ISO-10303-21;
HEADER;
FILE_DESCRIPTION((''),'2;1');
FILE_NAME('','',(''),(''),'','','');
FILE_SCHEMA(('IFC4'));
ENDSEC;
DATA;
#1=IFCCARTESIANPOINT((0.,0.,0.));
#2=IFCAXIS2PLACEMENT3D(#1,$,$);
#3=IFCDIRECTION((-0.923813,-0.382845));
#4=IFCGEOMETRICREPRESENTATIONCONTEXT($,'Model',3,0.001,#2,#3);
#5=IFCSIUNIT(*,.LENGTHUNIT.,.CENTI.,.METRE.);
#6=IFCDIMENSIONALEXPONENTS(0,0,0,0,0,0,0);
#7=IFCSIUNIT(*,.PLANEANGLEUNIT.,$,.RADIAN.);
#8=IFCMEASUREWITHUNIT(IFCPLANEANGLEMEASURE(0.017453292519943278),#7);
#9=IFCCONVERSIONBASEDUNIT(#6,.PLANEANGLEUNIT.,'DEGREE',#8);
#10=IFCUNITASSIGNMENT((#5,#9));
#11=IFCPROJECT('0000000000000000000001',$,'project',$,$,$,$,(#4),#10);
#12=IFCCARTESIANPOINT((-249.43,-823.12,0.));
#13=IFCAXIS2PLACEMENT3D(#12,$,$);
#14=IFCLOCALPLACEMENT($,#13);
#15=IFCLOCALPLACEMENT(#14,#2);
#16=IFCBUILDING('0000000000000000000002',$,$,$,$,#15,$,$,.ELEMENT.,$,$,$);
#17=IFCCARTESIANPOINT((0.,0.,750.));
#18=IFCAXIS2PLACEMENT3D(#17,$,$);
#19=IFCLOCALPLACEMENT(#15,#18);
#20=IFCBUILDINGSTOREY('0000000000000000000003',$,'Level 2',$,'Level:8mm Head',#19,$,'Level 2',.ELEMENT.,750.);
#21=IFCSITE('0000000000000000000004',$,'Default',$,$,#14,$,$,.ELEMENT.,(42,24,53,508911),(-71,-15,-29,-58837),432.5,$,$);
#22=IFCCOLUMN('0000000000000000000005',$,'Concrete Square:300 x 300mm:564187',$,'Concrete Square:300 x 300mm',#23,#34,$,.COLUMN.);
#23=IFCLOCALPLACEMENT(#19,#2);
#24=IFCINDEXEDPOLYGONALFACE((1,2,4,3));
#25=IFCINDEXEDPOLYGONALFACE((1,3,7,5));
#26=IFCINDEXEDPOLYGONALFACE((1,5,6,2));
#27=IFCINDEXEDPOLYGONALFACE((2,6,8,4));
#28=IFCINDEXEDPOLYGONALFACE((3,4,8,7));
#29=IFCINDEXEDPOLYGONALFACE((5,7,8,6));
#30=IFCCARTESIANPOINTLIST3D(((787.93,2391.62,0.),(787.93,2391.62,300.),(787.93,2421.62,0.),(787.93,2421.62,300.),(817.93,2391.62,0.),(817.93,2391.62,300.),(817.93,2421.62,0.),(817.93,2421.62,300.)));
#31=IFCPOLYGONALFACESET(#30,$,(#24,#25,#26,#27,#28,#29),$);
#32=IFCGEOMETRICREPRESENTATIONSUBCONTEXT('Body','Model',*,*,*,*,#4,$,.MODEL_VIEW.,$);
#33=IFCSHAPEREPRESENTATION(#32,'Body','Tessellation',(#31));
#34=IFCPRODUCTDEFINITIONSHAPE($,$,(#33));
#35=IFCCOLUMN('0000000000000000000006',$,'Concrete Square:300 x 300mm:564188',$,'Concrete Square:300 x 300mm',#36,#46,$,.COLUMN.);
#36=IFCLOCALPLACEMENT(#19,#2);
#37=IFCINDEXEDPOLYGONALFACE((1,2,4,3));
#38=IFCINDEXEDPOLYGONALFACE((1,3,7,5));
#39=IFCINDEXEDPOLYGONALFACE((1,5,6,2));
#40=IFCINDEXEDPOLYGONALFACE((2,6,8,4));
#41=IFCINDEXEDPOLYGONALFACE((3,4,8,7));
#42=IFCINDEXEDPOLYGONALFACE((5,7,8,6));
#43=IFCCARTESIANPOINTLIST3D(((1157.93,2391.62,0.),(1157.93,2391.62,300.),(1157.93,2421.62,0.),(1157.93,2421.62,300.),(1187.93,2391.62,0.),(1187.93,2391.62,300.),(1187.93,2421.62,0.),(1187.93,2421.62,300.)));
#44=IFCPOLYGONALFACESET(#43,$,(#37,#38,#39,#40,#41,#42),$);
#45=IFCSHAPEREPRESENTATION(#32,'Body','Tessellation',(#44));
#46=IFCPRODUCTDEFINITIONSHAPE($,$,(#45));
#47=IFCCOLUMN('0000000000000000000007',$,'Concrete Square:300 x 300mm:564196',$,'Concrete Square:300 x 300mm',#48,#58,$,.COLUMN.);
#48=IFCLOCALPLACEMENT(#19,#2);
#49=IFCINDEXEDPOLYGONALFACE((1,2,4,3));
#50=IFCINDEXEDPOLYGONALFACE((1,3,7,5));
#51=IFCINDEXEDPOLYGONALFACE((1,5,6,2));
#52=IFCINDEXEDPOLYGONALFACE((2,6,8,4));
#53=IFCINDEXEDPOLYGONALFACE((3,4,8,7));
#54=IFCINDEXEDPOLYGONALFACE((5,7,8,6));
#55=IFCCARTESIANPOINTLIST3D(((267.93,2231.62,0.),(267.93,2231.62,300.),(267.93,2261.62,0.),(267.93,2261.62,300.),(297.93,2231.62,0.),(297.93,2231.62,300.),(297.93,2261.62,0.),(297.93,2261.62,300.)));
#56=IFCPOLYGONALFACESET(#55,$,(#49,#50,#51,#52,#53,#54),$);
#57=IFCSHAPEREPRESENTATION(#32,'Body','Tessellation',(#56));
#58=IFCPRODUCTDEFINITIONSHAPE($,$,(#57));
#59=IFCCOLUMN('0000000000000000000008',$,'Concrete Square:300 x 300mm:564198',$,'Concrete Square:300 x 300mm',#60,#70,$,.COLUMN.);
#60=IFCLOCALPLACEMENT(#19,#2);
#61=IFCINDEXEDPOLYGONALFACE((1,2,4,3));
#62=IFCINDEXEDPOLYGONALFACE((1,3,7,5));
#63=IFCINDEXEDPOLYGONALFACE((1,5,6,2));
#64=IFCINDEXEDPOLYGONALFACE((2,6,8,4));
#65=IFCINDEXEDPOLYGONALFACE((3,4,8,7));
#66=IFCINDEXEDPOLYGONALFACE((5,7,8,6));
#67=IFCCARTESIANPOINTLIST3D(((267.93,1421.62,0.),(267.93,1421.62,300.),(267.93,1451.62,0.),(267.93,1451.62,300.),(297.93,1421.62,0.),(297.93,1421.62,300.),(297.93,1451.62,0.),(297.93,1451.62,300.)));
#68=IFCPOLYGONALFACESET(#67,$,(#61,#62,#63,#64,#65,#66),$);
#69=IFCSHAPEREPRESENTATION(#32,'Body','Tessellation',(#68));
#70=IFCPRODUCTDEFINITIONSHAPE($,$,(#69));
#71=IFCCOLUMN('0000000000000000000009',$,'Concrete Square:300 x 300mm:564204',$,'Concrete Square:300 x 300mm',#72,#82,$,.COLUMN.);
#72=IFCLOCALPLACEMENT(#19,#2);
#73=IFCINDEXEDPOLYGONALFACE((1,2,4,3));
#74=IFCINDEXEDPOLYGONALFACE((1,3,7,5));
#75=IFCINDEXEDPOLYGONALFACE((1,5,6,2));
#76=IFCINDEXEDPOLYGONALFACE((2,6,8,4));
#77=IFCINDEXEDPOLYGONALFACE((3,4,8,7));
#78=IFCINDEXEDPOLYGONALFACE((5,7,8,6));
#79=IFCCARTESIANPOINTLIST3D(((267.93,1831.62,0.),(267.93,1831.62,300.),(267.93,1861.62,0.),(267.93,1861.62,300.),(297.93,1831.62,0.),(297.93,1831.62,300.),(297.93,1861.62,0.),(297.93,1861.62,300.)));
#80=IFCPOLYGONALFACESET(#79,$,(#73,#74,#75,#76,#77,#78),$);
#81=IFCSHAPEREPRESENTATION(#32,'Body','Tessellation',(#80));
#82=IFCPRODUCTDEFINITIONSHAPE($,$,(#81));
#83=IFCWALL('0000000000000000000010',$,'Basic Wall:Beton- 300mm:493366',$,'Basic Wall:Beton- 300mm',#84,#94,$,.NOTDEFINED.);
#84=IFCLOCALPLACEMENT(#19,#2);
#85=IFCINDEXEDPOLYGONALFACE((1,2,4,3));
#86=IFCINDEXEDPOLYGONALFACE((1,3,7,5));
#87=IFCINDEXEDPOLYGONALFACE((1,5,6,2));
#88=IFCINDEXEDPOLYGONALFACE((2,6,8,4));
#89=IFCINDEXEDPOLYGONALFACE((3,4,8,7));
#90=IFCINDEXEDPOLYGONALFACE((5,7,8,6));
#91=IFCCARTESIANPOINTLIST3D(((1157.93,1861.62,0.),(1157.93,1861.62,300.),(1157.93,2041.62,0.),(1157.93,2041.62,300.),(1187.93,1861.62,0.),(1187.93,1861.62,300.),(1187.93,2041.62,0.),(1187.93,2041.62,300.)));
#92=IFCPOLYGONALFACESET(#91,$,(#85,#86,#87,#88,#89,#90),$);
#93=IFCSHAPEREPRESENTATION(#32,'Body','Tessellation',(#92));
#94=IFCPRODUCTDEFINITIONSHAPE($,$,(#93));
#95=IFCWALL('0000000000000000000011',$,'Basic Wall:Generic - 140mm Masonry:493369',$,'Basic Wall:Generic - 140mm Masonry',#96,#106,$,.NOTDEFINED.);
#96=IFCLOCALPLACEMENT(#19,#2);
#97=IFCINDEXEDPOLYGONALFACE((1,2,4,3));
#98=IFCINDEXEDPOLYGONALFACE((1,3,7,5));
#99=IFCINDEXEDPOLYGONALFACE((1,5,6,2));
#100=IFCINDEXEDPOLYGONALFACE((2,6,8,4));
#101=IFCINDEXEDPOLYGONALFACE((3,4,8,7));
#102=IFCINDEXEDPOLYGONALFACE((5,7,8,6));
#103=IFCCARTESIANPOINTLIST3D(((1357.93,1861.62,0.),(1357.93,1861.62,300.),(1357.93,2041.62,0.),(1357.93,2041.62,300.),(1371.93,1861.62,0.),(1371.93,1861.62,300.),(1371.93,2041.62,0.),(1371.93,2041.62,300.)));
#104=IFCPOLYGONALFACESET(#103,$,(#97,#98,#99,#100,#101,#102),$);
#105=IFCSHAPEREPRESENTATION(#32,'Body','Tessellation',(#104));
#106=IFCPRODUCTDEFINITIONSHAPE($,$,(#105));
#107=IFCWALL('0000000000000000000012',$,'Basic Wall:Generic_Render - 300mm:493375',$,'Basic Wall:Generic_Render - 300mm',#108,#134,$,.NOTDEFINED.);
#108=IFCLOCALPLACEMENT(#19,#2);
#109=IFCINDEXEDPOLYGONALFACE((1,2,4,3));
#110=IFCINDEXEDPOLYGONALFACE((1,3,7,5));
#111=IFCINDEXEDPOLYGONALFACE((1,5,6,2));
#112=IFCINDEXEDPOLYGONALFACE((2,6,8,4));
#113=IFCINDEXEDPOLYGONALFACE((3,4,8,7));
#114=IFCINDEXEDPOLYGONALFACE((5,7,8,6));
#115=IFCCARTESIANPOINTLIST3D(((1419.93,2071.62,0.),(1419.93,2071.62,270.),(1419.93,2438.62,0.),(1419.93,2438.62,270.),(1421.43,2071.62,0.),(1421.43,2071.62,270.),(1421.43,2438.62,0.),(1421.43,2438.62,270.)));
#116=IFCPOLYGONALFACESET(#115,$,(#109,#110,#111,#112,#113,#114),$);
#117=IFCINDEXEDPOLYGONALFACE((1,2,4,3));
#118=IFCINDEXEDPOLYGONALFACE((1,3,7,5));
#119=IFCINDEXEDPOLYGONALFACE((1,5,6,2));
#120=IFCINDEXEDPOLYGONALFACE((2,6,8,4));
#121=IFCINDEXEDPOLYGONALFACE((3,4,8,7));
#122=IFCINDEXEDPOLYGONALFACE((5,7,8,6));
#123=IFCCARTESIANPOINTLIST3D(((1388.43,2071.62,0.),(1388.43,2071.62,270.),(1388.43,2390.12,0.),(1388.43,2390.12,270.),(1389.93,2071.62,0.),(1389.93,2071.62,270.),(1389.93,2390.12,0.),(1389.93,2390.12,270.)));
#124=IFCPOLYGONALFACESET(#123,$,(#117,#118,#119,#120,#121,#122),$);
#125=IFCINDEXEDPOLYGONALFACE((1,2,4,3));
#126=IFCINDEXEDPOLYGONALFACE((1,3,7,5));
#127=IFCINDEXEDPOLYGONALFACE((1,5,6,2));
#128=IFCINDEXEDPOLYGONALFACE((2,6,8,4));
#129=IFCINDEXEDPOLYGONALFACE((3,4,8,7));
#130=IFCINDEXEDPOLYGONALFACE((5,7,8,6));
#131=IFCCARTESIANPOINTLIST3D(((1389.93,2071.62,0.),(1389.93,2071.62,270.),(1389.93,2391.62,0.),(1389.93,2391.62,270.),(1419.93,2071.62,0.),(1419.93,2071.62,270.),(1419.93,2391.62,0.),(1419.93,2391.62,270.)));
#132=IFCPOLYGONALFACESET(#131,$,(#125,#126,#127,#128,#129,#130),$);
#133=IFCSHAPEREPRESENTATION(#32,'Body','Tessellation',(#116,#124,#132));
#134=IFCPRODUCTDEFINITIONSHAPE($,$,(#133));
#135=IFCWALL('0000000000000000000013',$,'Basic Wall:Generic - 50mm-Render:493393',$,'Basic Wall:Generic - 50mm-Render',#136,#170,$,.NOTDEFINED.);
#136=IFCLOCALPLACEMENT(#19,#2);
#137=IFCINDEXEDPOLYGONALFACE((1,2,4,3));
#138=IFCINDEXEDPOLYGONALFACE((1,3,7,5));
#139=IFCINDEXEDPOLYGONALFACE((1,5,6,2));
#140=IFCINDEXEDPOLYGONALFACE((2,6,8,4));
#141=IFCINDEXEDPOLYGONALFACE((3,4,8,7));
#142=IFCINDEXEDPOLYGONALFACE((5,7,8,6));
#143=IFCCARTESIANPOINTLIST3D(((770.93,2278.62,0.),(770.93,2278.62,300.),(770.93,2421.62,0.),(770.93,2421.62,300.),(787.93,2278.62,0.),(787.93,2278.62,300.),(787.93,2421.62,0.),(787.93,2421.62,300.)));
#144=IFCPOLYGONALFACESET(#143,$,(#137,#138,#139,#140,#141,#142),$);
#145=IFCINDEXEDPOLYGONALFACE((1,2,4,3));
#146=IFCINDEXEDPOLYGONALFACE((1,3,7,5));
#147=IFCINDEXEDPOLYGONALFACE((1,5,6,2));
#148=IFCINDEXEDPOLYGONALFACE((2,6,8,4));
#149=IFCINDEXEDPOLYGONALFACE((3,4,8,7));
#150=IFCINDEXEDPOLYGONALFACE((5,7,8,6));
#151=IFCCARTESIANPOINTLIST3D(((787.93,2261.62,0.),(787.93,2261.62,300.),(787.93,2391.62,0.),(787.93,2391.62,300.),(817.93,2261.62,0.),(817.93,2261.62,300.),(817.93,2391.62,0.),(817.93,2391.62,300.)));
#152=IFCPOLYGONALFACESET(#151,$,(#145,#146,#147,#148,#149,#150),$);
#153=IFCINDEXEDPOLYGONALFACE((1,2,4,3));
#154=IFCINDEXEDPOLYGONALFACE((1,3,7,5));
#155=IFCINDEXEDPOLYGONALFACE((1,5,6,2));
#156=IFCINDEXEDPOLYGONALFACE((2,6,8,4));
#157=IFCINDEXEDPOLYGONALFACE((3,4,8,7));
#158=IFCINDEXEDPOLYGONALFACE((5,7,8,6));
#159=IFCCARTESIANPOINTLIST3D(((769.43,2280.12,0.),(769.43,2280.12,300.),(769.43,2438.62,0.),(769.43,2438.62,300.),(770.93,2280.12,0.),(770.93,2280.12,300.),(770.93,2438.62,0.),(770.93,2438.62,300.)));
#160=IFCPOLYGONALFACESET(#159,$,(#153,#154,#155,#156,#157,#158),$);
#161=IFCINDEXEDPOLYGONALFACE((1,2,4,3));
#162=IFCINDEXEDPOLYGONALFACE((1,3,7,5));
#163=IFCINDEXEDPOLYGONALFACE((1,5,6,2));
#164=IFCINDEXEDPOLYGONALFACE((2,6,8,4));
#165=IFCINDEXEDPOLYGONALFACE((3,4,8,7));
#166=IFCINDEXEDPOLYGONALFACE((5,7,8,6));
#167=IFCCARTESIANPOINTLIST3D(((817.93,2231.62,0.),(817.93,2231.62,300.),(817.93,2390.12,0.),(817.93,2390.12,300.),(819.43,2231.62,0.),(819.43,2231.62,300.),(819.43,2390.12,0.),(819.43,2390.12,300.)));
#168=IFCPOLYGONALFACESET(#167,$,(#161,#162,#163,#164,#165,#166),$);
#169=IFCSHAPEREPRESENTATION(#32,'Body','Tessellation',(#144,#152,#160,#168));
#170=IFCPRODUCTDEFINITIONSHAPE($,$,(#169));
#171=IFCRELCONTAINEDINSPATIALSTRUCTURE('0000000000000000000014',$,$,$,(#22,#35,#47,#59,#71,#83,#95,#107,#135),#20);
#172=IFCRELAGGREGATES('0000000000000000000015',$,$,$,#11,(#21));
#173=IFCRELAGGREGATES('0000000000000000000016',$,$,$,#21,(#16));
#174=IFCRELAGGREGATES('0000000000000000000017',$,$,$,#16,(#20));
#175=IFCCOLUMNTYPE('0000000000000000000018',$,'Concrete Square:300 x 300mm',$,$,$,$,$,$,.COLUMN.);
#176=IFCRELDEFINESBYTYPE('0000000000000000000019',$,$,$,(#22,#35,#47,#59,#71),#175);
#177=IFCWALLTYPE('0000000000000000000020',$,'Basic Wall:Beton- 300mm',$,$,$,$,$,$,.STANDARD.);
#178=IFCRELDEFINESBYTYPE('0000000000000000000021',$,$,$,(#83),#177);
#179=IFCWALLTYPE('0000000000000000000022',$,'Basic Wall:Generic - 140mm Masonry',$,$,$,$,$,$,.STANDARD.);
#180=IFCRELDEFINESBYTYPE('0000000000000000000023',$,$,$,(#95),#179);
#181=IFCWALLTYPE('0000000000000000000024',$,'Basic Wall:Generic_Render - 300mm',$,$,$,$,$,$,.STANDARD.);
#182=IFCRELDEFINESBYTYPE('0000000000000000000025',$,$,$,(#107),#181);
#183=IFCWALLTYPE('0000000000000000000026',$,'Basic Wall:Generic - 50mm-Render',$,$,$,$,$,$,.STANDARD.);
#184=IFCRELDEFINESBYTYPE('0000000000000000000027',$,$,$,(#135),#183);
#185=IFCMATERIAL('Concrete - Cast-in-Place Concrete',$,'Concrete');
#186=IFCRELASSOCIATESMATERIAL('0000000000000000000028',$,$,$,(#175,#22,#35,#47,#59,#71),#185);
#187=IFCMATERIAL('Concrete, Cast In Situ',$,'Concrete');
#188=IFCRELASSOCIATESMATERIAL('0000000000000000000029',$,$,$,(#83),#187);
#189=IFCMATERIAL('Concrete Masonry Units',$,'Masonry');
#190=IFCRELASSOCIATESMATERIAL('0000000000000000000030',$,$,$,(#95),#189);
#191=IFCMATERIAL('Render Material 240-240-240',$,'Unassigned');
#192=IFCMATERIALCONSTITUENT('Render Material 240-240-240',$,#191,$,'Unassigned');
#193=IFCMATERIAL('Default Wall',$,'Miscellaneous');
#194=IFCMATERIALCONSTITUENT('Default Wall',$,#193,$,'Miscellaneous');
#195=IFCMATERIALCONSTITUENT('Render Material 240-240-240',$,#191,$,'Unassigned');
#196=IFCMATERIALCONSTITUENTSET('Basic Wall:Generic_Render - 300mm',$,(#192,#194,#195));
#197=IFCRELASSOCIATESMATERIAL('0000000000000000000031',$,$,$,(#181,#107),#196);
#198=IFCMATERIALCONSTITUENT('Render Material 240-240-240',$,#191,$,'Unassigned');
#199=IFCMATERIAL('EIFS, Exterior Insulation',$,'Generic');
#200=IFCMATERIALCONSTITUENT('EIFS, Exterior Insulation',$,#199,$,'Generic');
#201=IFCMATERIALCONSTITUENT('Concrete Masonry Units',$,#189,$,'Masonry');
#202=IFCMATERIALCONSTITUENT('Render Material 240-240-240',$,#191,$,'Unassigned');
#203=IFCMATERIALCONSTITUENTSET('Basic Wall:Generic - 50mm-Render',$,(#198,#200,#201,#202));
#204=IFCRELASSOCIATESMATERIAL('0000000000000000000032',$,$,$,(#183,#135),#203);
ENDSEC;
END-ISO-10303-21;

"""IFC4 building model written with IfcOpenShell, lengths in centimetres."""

from ifc_helpers import new_model, entity, si_unit, converted_unit, direction, frame, origin, place, context, subcontext, project, spatial, indexed_curve, outline, extrude, source, transform, mapped, material, constituent, constituent_set, type_object, type_shapes, element, save


model = new_model("IFC4")

# Units and contexts
model_context = context("Model", 3, precision=0.001, world=origin(), true_north=direction((-0.923813, -0.382845)))
body_context = subcontext(model_context, "Body", "Model", "MODEL_VIEW")
ifc_project = project(units=[si_unit("LENGTHUNIT", "METRE", prefix="CENTI"), converted_unit("PLANEANGLEUNIT", "DEGREE", entity("IfcPlaneAngleMeasure", 0.017453292519943278), si_unit("PLANEANGLEUNIT", "RADIAN"), dimensions=[0, 0, 0, 0, 0, 0, 0])], contexts=[model_context])

# Site, building, storey
site_placement = place(None, frame((-249.43, -823.12, 0.0)))
site = spatial("IfcSite", under=ifc_project, at=site_placement, Name="Default", CompositionType="ELEMENT", RefLatitude=(42, 24, 53, 508911), RefLongitude=(-71, -15, -29, -58837), RefElevation=432.5)
building_placement = place(site_placement, origin())
building = spatial("IfcBuilding", under=site, at=building_placement, CompositionType="ELEMENT")
storey_placement = place(building_placement, frame((0.0, 0.0, 750.0)))
storey = spatial("IfcBuildingStorey", under=building, at=storey_placement, Name="Level 2", ObjectType="Level:8mm Head", LongName="Level 2", CompositionType="ELEMENT", Elevation=750.0)

# Columns
ifc_material_1 = material(Name="Concrete - Cast-in-Place Concrete", Category="Concrete")
column_type = type_object("IfcColumnType", Name="Concrete Square:300 x 300mm", PredefinedType="COLUMN", material=ifc_material_1)
shared_shape_1 = source(origin(), body_context, "Body", "SweptSolid", [
    extrude(outline(indexed_curve([(-15.0, -15.0), (15.0, -15.0), (15.0, 15.0), (-15.0, 15.0), (-15.0, -15.0)], self_intersect=False)), frame((0.0, 0.0, 750.0), z_axis=(0.0, 0.0, 1.0), x_axis=(-1.0, 0.0, 0.0)), (0.0, 0.0, 1.0), 300.0),
])
type_shapes(column_type, [shared_shape_1])
for number, where, name in (
    (1, (802.93, 2406.62, -750.0), "Concrete Square:300 x 300mm:564187"),
    (2, (1172.93, 2406.62, -750.0), "Concrete Square:300 x 300mm:564188"),
    (3, (282.93, 2246.62, -750.0), "Concrete Square:300 x 300mm:564196"),
    (4, (282.93, 1436.62, -750.0), "Concrete Square:300 x 300mm:564198"),
    (5, (282.93, 1846.62, -750.0), "Concrete Square:300 x 300mm:564204"),
):
    element("IfcColumn", number, at=place(storey_placement, frame(where)), inside=storey, type_object=column_type, material=ifc_material_1, Name=name, ObjectType="Concrete Square:300 x 300mm", PredefinedType="COLUMN", context=body_context, shape_type="MappedRepresentation", body=[
        mapped(shared_shape_1, transform((0.0, 0.0, 0.0), scale=1.0)),
    ])

# Walls
ifc_material_2 = material(Name="Concrete, Cast In Situ", Category="Concrete")
wall_type_1 = type_object("IfcWallType", Name="Basic Wall:Beton- 300mm", PredefinedType="STANDARD")
wall_1_placement = place(storey_placement, frame((1172.93, 2041.62, 0.0), z_axis=(0.0, 0.0, 1.0), x_axis=(0.0, -1.0, 0.0)))
element("IfcWall", 6, at=wall_1_placement, inside=storey, type_object=wall_type_1, material=ifc_material_2, Name="Basic Wall:Beton- 300mm:493366", ObjectType="Basic Wall:Beton- 300mm", PredefinedType="NOTDEFINED", context=body_context, shape_type="SweptSolid", body=[
    extrude(outline(indexed_curve([(180.0, 15.0), (0.0, 15.0), (0.0, -15.0), (180.0, -15.0), (180.0, 15.0)], self_intersect=False)), origin(), (0.0, 0.0, 1.0), 300.0),
])
ifc_material_3 = material(Name="Concrete Masonry Units", Category="Masonry")
wall_type_2 = type_object("IfcWallType", Name="Basic Wall:Generic - 140mm Masonry", PredefinedType="STANDARD")
wall_2_placement = place(storey_placement, frame((1364.93, 2041.62, 0.0), z_axis=(0.0, 0.0, 1.0), x_axis=(0.0, -1.0, 0.0)))
element("IfcWall", 7, at=wall_2_placement, inside=storey, type_object=wall_type_2, material=ifc_material_3, Name="Basic Wall:Generic - 140mm Masonry:493369", ObjectType="Basic Wall:Generic - 140mm Masonry", PredefinedType="NOTDEFINED", context=body_context, shape_type="SweptSolid", body=[
    extrude(outline(indexed_curve([(180.0, 7.0), (0.0, 7.0), (0.0, -7.0), (180.0, -7.0), (180.0, 7.0)], self_intersect=False)), origin(), (0.0, 0.0, 1.0), 300.0),
])
ifc_material_4 = material(Name="Render Material 240-240-240", Category="Unassigned")
ifc_constituent_1 = constituent(ifc_material_4, Name="Render Material 240-240-240", Category="Unassigned")
ifc_material_5 = material(Name="Default Wall", Category="Miscellaneous")
ifc_constituent_2 = constituent(ifc_material_5, Name="Default Wall", Category="Miscellaneous")
ifc_constituent_3 = constituent(ifc_material_4, Name="Render Material 240-240-240", Category="Unassigned")
ifc_constituent_set_1 = constituent_set(constituents=[ifc_constituent_1, ifc_constituent_2, ifc_constituent_3], Name="Basic Wall:Generic_Render - 300mm")
wall_type_3 = type_object("IfcWallType", Name="Basic Wall:Generic_Render - 300mm", PredefinedType="STANDARD", material=ifc_constituent_set_1)
wall_3_placement = place(storey_placement, frame((1404.93, 2071.62, 0.0), z_axis=(0.0, 0.0, 1.0), x_axis=(0.0, 1.0, 0.0)))
element("IfcWall", 8, at=wall_3_placement, inside=storey, type_object=wall_type_3, material=ifc_constituent_set_1, Name="Basic Wall:Generic_Render - 300mm:493375", ObjectType="Basic Wall:Generic_Render - 300mm", PredefinedType="NOTDEFINED", context=body_context, shape_type="SweptSolid", body=[
    extrude(outline(indexed_curve([(-0.75, -183.5), (0.75, -183.5), (0.75, 183.5), (-0.75, 183.5), (-0.75, -183.5)], self_intersect=False)), frame((183.5, -15.75, 0.0), z_axis=(0.0, 0.0, 1.0), x_axis=(0.0, 1.0, 0.0)), (0.0, 0.0, 1.0), 270.0),
    extrude(outline(indexed_curve([(-0.75, -159.25), (0.75, -159.25), (0.75, 159.25), (-0.75, 159.25), (-0.75, -159.25)], self_intersect=False)), frame((159.25, 15.75, 0.0), z_axis=(0.0, 0.0, 1.0), x_axis=(0.0, -1.0, 0.0)), (0.0, 0.0, 1.0), 270.0),
    extrude(outline(indexed_curve([(-160.0, -15.0), (160.0, -15.0), (160.0, 15.0), (-160.0, 15.0), (-160.0, -15.0)], self_intersect=False)), frame((160.0, 0.0, 0.0)), (0.0, 0.0, 1.0), 270.0),
])
ifc_constituent_4 = constituent(ifc_material_4, Name="Render Material 240-240-240", Category="Unassigned")
ifc_material_6 = material(Name="EIFS, Exterior Insulation", Category="Generic")
ifc_constituent_5 = constituent(ifc_material_6, Name="EIFS, Exterior Insulation", Category="Generic")
ifc_constituent_6 = constituent(ifc_material_3, Name="Concrete Masonry Units", Category="Masonry")
ifc_constituent_7 = constituent(ifc_material_4, Name="Render Material 240-240-240", Category="Unassigned")
ifc_constituent_set_2 = constituent_set(constituents=[ifc_constituent_4, ifc_constituent_5, ifc_constituent_6, ifc_constituent_7], Name="Basic Wall:Generic - 50mm-Render")
wall_type_4 = type_object("IfcWallType", Name="Basic Wall:Generic - 50mm-Render", PredefinedType="STANDARD", material=ifc_constituent_set_2)
wall_4_placement = place(storey_placement, frame((794.43, 2280.12, 0.0), z_axis=(0.0, 0.0, 1.0), x_axis=(0.0, 1.0, 0.0)))
element("IfcWall", 9, at=wall_4_placement, inside=storey, type_object=wall_type_4, material=ifc_constituent_set_2, Name="Basic Wall:Generic - 50mm-Render:493393", ObjectType="Basic Wall:Generic - 50mm-Render", PredefinedType="NOTDEFINED", context=body_context, shape_type="SweptSolid", body=[
    extrude(outline(indexed_curve([(-8.5, -71.5), (8.5, -71.5), (8.5, 71.5), (-8.5, 71.5), (-8.5, -71.5)], self_intersect=False)), frame((70.0, 15.0, 0.0), z_axis=(0.0, 0.0, 1.0), x_axis=(0.0, -1.0, 0.0)), (0.0, 0.0, 1.0), 300.0),
    extrude(outline(indexed_curve([(-15.0, -65.0), (15.0, -65.0), (15.0, 65.0), (-15.0, 65.0), (-15.0, -65.0)], self_intersect=False)), frame((46.5, -8.5, 0.0), z_axis=(0.0, 0.0, 1.0), x_axis=(0.0, 1.0, 0.0)), (0.0, 0.0, 1.0), 300.0),
    extrude(outline(indexed_curve([(-0.75, -79.25), (0.75, -79.25), (0.75, 79.25), (-0.75, 79.25), (-0.75, -79.25)], self_intersect=False)), frame((79.25, 24.25, 0.0), z_axis=(0.0, 0.0, 1.0), x_axis=(0.0, -1.0, 0.0)), (0.0, 0.0, 1.0), 300.0),
    extrude(outline(indexed_curve([(-0.75, -79.25), (0.75, -79.25), (0.75, 79.25), (-0.75, 79.25), (-0.75, -79.25)], self_intersect=False)), frame((30.75, -24.25, 0.0), z_axis=(0.0, 0.0, 1.0), x_axis=(0.0, -1.0, 0.0)), (0.0, 0.0, 1.0), 300.0),
])

save(model, "model.ifc")
